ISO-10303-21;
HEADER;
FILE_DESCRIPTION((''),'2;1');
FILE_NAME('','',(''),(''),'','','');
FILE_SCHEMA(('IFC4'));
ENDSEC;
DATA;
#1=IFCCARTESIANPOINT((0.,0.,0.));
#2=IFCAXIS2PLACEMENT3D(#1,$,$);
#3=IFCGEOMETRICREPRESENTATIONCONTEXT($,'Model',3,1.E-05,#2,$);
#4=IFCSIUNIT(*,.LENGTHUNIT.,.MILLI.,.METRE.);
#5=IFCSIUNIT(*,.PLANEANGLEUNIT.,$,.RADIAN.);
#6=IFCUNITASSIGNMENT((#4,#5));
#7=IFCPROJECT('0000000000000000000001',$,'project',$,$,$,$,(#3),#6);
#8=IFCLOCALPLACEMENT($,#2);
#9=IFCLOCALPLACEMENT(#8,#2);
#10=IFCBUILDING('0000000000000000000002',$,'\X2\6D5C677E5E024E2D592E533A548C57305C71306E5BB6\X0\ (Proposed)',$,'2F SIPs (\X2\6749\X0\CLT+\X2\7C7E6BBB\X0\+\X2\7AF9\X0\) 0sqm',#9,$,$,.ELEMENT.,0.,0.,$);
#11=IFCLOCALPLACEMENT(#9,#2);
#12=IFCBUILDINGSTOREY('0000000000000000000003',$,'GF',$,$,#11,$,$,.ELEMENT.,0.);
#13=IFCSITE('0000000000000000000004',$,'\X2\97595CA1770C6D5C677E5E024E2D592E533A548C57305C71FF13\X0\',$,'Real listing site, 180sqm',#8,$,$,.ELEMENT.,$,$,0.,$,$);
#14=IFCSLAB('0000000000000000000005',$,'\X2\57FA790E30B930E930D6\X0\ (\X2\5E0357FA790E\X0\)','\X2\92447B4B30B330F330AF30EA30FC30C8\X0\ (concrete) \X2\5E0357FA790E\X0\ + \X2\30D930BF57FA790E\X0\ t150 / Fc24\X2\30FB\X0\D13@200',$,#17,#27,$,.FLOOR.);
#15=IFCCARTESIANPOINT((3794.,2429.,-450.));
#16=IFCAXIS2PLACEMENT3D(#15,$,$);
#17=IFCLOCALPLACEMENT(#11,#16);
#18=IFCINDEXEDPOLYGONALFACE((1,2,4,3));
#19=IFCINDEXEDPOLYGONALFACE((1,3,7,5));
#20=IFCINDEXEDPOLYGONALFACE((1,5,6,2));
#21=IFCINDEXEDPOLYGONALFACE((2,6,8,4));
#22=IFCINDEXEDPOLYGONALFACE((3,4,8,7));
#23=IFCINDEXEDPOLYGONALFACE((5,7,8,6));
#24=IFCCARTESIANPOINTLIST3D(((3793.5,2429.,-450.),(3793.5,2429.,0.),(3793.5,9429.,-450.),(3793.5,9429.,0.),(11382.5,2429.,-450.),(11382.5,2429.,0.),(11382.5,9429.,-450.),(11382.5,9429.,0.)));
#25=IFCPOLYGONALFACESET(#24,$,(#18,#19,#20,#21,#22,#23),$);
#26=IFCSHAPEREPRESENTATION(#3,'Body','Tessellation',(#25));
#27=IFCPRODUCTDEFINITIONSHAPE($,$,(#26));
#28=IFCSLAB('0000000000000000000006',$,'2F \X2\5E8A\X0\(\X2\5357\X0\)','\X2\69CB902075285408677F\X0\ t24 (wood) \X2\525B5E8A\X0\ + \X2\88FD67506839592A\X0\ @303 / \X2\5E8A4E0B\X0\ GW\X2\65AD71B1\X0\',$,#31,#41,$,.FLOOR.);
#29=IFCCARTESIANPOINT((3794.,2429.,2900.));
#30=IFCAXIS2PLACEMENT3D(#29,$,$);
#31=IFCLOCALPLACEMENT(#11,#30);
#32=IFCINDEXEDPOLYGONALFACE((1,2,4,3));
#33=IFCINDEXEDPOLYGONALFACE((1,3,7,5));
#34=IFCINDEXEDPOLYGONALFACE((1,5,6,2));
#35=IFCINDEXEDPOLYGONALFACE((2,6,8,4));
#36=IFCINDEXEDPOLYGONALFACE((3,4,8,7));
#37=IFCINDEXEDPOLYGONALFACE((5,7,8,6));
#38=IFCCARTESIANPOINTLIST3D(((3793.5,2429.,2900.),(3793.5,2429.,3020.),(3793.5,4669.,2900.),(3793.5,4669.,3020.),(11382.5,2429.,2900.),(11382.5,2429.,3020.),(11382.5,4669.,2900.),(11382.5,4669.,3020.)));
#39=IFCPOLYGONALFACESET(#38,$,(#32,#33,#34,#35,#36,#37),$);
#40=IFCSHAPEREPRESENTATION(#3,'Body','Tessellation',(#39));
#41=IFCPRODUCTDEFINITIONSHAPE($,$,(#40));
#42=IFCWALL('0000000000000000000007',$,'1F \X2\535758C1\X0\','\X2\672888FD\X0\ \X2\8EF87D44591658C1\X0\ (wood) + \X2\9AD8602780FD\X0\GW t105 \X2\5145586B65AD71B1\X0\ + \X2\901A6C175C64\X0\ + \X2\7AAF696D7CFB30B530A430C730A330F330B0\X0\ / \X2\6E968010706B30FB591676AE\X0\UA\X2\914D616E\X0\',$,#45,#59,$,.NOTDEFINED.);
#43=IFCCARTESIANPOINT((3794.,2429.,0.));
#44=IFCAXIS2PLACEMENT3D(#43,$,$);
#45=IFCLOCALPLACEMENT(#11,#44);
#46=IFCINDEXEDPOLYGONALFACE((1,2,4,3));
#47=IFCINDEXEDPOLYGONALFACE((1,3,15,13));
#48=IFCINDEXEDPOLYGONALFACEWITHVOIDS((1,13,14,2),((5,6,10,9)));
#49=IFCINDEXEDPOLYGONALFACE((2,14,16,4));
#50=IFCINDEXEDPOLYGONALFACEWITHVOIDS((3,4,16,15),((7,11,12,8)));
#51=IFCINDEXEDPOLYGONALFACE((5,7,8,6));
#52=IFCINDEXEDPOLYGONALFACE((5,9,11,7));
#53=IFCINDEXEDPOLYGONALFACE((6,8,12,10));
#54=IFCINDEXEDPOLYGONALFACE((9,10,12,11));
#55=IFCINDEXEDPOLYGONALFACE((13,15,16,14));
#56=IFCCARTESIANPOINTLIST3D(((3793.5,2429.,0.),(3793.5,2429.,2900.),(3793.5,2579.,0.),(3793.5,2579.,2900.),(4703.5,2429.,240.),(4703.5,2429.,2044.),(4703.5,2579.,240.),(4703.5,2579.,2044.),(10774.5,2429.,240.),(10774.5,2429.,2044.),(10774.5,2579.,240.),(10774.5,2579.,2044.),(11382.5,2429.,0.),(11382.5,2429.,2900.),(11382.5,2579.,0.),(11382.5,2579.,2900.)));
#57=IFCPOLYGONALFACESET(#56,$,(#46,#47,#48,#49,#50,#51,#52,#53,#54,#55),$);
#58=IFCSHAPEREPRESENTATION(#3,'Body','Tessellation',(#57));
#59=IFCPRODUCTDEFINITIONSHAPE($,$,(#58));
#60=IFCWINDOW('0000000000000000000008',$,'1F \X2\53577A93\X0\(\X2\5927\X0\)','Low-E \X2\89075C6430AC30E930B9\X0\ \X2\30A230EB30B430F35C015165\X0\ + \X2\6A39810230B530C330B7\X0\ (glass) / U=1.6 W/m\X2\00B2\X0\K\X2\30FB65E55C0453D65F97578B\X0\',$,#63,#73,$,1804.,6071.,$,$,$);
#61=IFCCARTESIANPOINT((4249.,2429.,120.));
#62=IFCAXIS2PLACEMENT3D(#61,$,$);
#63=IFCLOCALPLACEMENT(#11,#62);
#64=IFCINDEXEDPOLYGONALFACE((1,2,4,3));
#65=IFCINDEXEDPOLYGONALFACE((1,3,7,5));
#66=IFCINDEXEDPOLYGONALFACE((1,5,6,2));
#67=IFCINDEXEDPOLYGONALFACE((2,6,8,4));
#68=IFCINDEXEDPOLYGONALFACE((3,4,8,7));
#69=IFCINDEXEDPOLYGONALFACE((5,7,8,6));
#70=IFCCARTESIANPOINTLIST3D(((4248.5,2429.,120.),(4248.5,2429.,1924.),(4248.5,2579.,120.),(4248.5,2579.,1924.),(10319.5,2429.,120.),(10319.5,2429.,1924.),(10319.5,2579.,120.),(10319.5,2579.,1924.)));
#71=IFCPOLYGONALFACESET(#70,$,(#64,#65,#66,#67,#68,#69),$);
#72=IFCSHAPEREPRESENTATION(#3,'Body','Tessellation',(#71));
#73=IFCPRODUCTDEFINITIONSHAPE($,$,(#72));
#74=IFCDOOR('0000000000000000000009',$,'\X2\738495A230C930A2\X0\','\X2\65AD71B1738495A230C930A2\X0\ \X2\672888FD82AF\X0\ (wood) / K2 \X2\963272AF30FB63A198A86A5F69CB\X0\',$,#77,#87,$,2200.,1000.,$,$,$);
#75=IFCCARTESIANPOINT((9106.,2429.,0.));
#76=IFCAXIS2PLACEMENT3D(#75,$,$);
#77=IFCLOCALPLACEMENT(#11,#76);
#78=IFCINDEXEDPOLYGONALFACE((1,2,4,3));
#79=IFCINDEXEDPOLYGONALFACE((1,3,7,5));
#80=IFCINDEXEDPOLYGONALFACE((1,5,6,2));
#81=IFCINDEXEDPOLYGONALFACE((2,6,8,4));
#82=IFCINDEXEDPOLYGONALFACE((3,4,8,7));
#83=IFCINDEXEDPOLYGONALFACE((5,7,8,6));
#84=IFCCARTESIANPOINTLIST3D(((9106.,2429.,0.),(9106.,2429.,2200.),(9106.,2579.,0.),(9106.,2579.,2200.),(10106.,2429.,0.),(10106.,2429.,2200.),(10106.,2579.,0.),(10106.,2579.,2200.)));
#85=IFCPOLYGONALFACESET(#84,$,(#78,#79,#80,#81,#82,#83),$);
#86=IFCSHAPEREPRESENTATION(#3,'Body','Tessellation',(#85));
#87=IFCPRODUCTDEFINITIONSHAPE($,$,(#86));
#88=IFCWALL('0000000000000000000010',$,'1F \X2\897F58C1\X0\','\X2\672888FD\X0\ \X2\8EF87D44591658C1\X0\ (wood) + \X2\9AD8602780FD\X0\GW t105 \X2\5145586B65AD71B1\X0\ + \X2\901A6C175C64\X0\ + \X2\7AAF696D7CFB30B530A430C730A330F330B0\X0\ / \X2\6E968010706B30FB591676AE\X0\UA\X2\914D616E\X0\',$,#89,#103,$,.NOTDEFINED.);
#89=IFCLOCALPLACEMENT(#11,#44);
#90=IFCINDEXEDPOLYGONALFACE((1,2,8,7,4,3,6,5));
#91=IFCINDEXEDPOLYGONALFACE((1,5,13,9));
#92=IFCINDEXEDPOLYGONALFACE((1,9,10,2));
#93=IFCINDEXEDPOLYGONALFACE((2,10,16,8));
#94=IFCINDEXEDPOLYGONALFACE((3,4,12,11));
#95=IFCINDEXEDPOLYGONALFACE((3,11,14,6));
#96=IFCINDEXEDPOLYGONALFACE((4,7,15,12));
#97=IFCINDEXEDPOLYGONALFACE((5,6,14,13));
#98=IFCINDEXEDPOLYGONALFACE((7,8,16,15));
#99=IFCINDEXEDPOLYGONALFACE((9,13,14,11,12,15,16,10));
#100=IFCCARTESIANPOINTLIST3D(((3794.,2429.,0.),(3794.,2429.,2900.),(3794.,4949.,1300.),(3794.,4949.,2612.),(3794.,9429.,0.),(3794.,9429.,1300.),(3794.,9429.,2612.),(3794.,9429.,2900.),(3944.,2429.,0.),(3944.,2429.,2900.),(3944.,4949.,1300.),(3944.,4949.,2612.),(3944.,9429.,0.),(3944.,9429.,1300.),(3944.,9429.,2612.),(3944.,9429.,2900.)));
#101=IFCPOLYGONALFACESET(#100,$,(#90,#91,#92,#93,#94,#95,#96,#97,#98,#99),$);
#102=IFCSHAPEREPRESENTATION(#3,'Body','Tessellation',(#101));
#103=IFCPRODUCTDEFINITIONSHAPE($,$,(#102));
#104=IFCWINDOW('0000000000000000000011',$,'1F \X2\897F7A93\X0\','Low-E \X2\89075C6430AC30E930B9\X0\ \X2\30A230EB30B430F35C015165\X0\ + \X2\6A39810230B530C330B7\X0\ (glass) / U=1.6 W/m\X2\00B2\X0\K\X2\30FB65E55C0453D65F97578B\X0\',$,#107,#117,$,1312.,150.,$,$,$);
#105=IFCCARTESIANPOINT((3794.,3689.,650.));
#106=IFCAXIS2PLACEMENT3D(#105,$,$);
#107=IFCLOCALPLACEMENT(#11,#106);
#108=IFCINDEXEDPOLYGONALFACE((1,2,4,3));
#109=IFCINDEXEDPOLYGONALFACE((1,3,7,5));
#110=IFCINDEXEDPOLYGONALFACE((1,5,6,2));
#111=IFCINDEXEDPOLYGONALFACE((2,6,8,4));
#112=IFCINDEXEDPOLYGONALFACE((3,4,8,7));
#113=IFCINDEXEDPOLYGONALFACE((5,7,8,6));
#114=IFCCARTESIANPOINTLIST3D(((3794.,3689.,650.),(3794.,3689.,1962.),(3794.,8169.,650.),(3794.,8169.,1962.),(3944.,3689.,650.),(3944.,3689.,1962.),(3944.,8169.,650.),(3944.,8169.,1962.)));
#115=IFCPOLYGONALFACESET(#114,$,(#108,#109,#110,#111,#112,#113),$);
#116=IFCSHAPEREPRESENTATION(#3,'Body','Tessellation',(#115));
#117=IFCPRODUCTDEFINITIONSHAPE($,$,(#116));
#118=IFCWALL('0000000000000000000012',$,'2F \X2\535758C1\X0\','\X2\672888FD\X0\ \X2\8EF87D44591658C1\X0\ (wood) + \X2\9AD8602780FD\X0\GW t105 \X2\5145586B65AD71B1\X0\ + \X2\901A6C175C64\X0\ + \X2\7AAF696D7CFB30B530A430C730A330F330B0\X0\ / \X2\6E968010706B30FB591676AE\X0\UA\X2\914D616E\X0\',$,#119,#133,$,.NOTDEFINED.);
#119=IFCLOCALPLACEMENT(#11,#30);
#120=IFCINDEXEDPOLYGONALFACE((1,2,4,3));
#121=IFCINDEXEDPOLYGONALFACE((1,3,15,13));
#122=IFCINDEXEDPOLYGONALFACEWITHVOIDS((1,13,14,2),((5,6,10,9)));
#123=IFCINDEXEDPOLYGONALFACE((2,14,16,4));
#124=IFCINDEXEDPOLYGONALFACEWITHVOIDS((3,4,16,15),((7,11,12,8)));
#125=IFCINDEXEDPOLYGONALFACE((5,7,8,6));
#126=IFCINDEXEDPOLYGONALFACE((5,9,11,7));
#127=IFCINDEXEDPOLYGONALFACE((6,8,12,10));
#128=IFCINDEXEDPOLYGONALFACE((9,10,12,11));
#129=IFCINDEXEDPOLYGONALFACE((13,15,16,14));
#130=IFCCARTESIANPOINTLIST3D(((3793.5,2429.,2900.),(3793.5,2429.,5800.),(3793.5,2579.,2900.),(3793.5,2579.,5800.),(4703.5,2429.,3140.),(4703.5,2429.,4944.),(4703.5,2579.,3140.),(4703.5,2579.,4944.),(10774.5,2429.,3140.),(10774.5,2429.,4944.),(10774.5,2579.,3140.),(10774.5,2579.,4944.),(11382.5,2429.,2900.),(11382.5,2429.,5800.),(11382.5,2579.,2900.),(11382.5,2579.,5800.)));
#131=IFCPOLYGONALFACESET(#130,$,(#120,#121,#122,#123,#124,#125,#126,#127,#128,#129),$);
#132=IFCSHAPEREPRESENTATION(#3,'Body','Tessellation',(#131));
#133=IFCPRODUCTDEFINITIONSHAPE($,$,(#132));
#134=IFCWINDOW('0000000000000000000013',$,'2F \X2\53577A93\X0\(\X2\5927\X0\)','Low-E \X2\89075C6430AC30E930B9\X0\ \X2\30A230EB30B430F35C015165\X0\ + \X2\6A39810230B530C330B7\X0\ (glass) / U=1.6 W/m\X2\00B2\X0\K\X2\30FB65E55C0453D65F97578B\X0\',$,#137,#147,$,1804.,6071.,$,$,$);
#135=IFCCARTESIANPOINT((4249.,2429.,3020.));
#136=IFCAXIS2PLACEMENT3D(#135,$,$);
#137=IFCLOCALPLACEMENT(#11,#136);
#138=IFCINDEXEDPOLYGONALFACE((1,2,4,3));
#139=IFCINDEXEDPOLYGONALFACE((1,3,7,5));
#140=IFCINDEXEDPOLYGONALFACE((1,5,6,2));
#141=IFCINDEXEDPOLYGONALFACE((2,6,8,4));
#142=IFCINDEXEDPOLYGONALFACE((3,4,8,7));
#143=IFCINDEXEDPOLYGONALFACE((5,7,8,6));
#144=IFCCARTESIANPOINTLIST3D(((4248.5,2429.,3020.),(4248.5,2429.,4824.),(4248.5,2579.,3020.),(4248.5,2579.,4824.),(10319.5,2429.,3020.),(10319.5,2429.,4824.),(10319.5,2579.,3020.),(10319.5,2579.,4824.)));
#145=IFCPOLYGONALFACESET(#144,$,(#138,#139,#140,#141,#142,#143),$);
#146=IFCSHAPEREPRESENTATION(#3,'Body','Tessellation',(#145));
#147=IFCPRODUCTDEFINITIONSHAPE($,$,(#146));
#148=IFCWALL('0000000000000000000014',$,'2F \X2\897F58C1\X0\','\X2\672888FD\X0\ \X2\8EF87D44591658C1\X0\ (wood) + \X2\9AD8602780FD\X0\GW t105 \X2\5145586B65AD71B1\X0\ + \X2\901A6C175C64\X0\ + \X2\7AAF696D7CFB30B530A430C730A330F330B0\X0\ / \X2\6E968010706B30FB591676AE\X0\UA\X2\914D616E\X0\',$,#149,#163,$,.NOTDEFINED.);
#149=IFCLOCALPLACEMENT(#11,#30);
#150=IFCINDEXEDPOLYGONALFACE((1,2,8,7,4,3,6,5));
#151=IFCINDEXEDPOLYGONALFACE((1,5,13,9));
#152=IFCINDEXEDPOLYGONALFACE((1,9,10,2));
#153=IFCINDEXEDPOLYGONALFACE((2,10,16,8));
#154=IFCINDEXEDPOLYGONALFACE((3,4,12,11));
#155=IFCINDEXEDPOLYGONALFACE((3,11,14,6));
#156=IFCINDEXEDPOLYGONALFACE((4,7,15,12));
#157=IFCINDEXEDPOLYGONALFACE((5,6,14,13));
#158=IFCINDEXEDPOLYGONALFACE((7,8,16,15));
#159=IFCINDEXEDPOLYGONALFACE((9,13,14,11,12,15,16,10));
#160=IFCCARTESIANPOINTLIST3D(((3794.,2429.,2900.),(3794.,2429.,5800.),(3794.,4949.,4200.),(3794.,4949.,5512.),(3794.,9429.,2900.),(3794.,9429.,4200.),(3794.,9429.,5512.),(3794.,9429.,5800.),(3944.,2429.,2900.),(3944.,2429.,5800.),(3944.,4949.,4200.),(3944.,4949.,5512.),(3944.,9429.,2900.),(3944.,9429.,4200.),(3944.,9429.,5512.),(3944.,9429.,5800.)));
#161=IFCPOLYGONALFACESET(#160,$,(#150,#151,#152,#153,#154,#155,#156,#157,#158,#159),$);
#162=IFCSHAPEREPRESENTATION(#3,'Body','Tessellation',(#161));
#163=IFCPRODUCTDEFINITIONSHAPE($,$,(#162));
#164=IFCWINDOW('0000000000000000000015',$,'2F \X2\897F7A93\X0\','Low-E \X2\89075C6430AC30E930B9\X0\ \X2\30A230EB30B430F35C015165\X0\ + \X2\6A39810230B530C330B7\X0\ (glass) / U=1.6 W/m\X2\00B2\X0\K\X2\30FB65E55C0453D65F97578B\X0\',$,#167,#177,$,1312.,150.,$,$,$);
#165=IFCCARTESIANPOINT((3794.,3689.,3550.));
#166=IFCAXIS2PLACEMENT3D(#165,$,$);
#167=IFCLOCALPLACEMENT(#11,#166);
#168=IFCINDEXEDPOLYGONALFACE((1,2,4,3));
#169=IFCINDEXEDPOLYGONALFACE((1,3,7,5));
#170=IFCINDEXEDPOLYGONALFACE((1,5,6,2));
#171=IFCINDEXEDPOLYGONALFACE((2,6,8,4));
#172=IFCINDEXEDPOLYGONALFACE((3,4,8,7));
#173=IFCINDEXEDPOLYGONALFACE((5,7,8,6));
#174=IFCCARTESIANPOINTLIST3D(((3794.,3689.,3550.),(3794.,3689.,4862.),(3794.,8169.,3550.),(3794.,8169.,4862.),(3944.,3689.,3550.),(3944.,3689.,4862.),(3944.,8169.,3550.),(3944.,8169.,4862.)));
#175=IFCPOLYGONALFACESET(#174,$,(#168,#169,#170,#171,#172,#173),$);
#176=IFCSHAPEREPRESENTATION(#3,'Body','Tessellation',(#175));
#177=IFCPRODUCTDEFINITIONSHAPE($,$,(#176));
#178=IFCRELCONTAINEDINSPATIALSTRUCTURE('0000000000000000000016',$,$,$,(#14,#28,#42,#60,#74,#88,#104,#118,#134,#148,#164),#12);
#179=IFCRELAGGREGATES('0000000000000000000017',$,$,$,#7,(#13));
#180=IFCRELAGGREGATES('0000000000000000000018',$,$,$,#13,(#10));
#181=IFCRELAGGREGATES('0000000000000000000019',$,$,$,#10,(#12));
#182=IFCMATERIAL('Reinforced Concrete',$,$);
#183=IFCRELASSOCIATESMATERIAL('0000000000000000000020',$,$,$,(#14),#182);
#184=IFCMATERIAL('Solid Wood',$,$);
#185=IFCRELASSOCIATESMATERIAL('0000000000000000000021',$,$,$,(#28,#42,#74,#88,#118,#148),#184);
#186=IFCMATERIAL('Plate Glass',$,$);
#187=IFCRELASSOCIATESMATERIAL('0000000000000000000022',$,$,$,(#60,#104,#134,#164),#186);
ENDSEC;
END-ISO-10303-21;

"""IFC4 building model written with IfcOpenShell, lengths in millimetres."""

from ifc_helpers import new_model, si_unit, frame, frame_2d, origin, place, context, project, spatial, rectangle, extrude, material, element, fill, save


model = new_model("IFC4")

# Units and contexts
model_context = context("Model", 3, precision=1e-05, world=origin())
ifc_project = project(units=[si_unit("LENGTHUNIT", "METRE", prefix="MILLI"), si_unit("PLANEANGLEUNIT", "RADIAN")], contexts=[model_context])

# Site, building, storey
site_placement = place(None, origin())
site = spatial("IfcSite", under=ifc_project, at=site_placement, Name="静岡県浜松市中央区和地山３", ObjectType="Real listing site, 180sqm", CompositionType="ELEMENT", RefElevation=0.0)
building_placement = place(site_placement, origin())
building = spatial("IfcBuilding", under=site, at=building_placement, Name="浜松市中央区和地山の家 (Proposed)", ObjectType="2F SIPs (杉CLT+籾殻+竹) 0sqm", CompositionType="ELEMENT", ElevationOfRefHeight=0.0, ElevationOfTerrain=0.0)
storey_placement = place(building_placement, origin())
storey = spatial("IfcBuildingStorey", under=building, at=storey_placement, Name="GF", CompositionType="ELEMENT", Elevation=0.0)

# Slabs
ifc_material_1 = material(Name="Reinforced Concrete")
slab_1_placement = place(storey_placement, frame((3794.0, 2429.0, -450.0)))
element("IfcSlab", 1, at=slab_1_placement, inside=storey, material=ifc_material_1, Name="基礎スラブ (布基礎)", Description="鉄筋コンクリート (concrete) 布基礎 + ベタ基礎 t150 / Fc24・D13@200", PredefinedType="FLOOR", context=model_context, shape_type="SweptSolid", body=[
    extrude(rectangle(XDim=7589.0, YDim=7000.0, at=frame_2d((3794.0, 3500.0))), frame((3794.0, 2429.0, -450.0)), (0.0, 0.0, 1.0), 450.0),
])
ifc_material_2 = material(Name="Solid Wood")
slab_2_placement = place(storey_placement, frame((3794.0, 2429.0, 2900.0)))
element("IfcSlab", 2, at=slab_2_placement, inside=storey, material=ifc_material_2, Name="2F 床(南)", Description="構造用合板 t24 (wood) 剛床 + 製材根太 @303 / 床下 GW断熱", PredefinedType="FLOOR", context=model_context, shape_type="SweptSolid", body=[
    extrude(rectangle(XDim=7589.0, YDim=2240.0, at=frame_2d((3794.0, 1120.0))), frame((3794.0, 2429.0, 2900.0)), (0.0, 0.0, 1.0), 120.0),
])

# Wall, openings, window, door
wall_1_placement = place(storey_placement, frame((3794.0, 2429.0, 0.0)))
wall_1 = element("IfcWall", 3, at=wall_1_placement, inside=storey, material=ifc_material_2, Name="1F 南壁", Description="木製 軸組外壁 (wood) + 高性能GW t105 充填断熱 + 通気層 + 窯業系サイディング / 準耐火・外皮UA配慮", PredefinedType="NOTDEFINED", context=model_context, shape_type="SweptSolid", body=[
    extrude(rectangle(XDim=7589.0, YDim=150.0, at=frame_2d((3794.0, 75.0))), frame((3794.0, 2429.0, 0.0)), (0.0, 0.0, 1.0), 2900.0),
])
opening_1_placement = place(storey_placement, frame((4249.0, 2429.0, 120.0)))
opening_1 = element("IfcOpeningElement", 4, at=opening_1_placement, cuts=wall_1, PredefinedType="NOTDEFINED", context=model_context, shape_type="SweptSolid", body=[
    extrude(rectangle(XDim=6071.0, YDim=150.0, at=frame_2d((3035.0, 75.0))), frame((4249.0, 2429.0, 120.0)), (0.0, 0.0, 1.0), 1804.0),
])
opening_2_placement = place(storey_placement, frame((9106.0, 2429.0, 0.0)))
opening_2 = element("IfcOpeningElement", 5, at=opening_2_placement, cuts=wall_1, PredefinedType="NOTDEFINED", context=model_context, shape_type="SweptSolid", body=[
    extrude(rectangle(XDim=1000.0, YDim=150.0, at=frame_2d((500.0, 75.0))), frame((9106.0, 2429.0, 0.0)), (0.0, 0.0, 1.0), 2200.0),
])
ifc_material_3 = material(Name="Plate Glass")
window_1_placement = place(storey_placement, frame((4249.0, 2429.0, 120.0)))
window_1 = element("IfcWindow", 6, at=window_1_placement, inside=storey, material=ifc_material_3, Name="1F 南窓(大)", Description="Low-E 複層ガラス アルゴン封入 + 樹脂サッシ (glass) / U=1.6 W/m²K・日射取得型", OverallHeight=1804.0, OverallWidth=6071.0, context=model_context, shape_type="SweptSolid", body=[
    extrude(rectangle(XDim=6071.0, YDim=150.0, at=frame_2d((3035.0, 75.0))), frame((4249.0, 2429.0, 120.0)), (0.0, 0.0, 1.0), 1804.0),
])
fill(opening_1, window_1)
door_placement = place(storey_placement, frame((9106.0, 2429.0, 0.0)))
door = element("IfcDoor", 7, at=door_placement, inside=storey, material=ifc_material_2, Name="玄関ドア", Description="断熱玄関ドア 木製芯 (wood) / K2 防犯・採風機構", OverallHeight=2200.0, OverallWidth=1000.0, context=model_context, shape_type="SweptSolid", body=[
    extrude(rectangle(XDim=1000.0, YDim=150.0, at=frame_2d((500.0, 75.0))), frame((9106.0, 2429.0, 0.0)), (0.0, 0.0, 1.0), 2200.0),
])
fill(opening_2, door)

# Walls, openings, windows
wall_2_placement = place(storey_placement, frame((3794.0, 2429.0, 0.0)))
wall_2 = element("IfcWall", 8, at=wall_2_placement, inside=storey, material=ifc_material_2, Name="1F 西壁", Description="木製 軸組外壁 (wood) + 高性能GW t105 充填断熱 + 通気層 + 窯業系サイディング / 準耐火・外皮UA配慮", PredefinedType="NOTDEFINED", context=model_context, shape_type="SweptSolid", body=[
    extrude(rectangle(XDim=150.0, YDim=7000.0, at=frame_2d((75.0, 3500.0))), frame((3794.0, 2429.0, 0.0)), (0.0, 0.0, 1.0), 2900.0),
])
opening_3_placement = place(storey_placement, frame((3794.0, 3689.0, 650.0)))
opening_3 = element("IfcOpeningElement", 9, at=opening_3_placement, cuts=wall_2, PredefinedType="NOTDEFINED", context=model_context, shape_type="SweptSolid", body=[
    extrude(rectangle(XDim=150.0, YDim=4480.0, at=frame_2d((75.0, 2240.0))), frame((3794.0, 3689.0, 650.0)), (0.0, 0.0, 1.0), 1312.0),
])
window_2_placement = place(storey_placement, frame((3794.0, 3689.0, 650.0)))
window_2 = element("IfcWindow", 10, at=window_2_placement, inside=storey, material=ifc_material_3, Name="1F 西窓", Description="Low-E 複層ガラス アルゴン封入 + 樹脂サッシ (glass) / U=1.6 W/m²K・日射取得型", OverallHeight=1312.0, OverallWidth=150.0, context=model_context, shape_type="SweptSolid", body=[
    extrude(rectangle(XDim=150.0, YDim=4480.0, at=frame_2d((75.0, 2240.0))), frame((3794.0, 3689.0, 650.0)), (0.0, 0.0, 1.0), 1312.0),
])
fill(opening_3, window_2)
wall_3_placement = place(storey_placement, frame((3794.0, 2429.0, 2900.0)))
wall_3 = element("IfcWall", 11, at=wall_3_placement, inside=storey, material=ifc_material_2, Name="2F 南壁", Description="木製 軸組外壁 (wood) + 高性能GW t105 充填断熱 + 通気層 + 窯業系サイディング / 準耐火・外皮UA配慮", PredefinedType="NOTDEFINED", context=model_context, shape_type="SweptSolid", body=[
    extrude(rectangle(XDim=7589.0, YDim=150.0, at=frame_2d((3794.0, 75.0))), frame((3794.0, 2429.0, 2900.0)), (0.0, 0.0, 1.0), 2900.0),
])
opening_4_placement = place(storey_placement, frame((4249.0, 2429.0, 3020.0)))
opening_4 = element("IfcOpeningElement", 12, at=opening_4_placement, cuts=wall_3, PredefinedType="NOTDEFINED", context=model_context, shape_type="SweptSolid", body=[
    extrude(rectangle(XDim=6071.0, YDim=150.0, at=frame_2d((3035.0, 75.0))), frame((4249.0, 2429.0, 3020.0)), (0.0, 0.0, 1.0), 1804.0),
])
window_3_placement = place(storey_placement, frame((4249.0, 2429.0, 3020.0)))
window_3 = element("IfcWindow", 13, at=window_3_placement, inside=storey, material=ifc_material_3, Name="2F 南窓(大)", Description="Low-E 複層ガラス アルゴン封入 + 樹脂サッシ (glass) / U=1.6 W/m²K・日射取得型", OverallHeight=1804.0, OverallWidth=6071.0, context=model_context, shape_type="SweptSolid", body=[
    extrude(rectangle(XDim=6071.0, YDim=150.0, at=frame_2d((3035.0, 75.0))), frame((4249.0, 2429.0, 3020.0)), (0.0, 0.0, 1.0), 1804.0),
])
fill(opening_4, window_3)
wall_4_placement = place(storey_placement, frame((3794.0, 2429.0, 2900.0)))
wall_4 = element("IfcWall", 14, at=wall_4_placement, inside=storey, material=ifc_material_2, Name="2F 西壁", Description="木製 軸組外壁 (wood) + 高性能GW t105 充填断熱 + 通気層 + 窯業系サイディング / 準耐火・外皮UA配慮", PredefinedType="NOTDEFINED", context=model_context, shape_type="SweptSolid", body=[
    extrude(rectangle(XDim=150.0, YDim=7000.0, at=frame_2d((75.0, 3500.0))), frame((3794.0, 2429.0, 2900.0)), (0.0, 0.0, 1.0), 2900.0),
])
opening_5_placement = place(storey_placement, frame((3794.0, 3689.0, 3550.0)))
opening_5 = element("IfcOpeningElement", 15, at=opening_5_placement, cuts=wall_4, PredefinedType="NOTDEFINED", context=model_context, shape_type="SweptSolid", body=[
    extrude(rectangle(XDim=150.0, YDim=4480.0, at=frame_2d((75.0, 2240.0))), frame((3794.0, 3689.0, 3550.0)), (0.0, 0.0, 1.0), 1312.0),
])
window_4_placement = place(storey_placement, frame((3794.0, 3689.0, 3550.0)))
window_4 = element("IfcWindow", 16, at=window_4_placement, inside=storey, material=ifc_material_3, Name="2F 西窓", Description="Low-E 複層ガラス アルゴン封入 + 樹脂サッシ (glass) / U=1.6 W/m²K・日射取得型", OverallHeight=1312.0, OverallWidth=150.0, context=model_context, shape_type="SweptSolid", body=[
    extrude(rectangle(XDim=150.0, YDim=4480.0, at=frame_2d((75.0, 2240.0))), frame((3794.0, 3689.0, 3550.0)), (0.0, 0.0, 1.0), 1312.0),
])
fill(opening_5, window_4)

save(model, "model.ifc")
